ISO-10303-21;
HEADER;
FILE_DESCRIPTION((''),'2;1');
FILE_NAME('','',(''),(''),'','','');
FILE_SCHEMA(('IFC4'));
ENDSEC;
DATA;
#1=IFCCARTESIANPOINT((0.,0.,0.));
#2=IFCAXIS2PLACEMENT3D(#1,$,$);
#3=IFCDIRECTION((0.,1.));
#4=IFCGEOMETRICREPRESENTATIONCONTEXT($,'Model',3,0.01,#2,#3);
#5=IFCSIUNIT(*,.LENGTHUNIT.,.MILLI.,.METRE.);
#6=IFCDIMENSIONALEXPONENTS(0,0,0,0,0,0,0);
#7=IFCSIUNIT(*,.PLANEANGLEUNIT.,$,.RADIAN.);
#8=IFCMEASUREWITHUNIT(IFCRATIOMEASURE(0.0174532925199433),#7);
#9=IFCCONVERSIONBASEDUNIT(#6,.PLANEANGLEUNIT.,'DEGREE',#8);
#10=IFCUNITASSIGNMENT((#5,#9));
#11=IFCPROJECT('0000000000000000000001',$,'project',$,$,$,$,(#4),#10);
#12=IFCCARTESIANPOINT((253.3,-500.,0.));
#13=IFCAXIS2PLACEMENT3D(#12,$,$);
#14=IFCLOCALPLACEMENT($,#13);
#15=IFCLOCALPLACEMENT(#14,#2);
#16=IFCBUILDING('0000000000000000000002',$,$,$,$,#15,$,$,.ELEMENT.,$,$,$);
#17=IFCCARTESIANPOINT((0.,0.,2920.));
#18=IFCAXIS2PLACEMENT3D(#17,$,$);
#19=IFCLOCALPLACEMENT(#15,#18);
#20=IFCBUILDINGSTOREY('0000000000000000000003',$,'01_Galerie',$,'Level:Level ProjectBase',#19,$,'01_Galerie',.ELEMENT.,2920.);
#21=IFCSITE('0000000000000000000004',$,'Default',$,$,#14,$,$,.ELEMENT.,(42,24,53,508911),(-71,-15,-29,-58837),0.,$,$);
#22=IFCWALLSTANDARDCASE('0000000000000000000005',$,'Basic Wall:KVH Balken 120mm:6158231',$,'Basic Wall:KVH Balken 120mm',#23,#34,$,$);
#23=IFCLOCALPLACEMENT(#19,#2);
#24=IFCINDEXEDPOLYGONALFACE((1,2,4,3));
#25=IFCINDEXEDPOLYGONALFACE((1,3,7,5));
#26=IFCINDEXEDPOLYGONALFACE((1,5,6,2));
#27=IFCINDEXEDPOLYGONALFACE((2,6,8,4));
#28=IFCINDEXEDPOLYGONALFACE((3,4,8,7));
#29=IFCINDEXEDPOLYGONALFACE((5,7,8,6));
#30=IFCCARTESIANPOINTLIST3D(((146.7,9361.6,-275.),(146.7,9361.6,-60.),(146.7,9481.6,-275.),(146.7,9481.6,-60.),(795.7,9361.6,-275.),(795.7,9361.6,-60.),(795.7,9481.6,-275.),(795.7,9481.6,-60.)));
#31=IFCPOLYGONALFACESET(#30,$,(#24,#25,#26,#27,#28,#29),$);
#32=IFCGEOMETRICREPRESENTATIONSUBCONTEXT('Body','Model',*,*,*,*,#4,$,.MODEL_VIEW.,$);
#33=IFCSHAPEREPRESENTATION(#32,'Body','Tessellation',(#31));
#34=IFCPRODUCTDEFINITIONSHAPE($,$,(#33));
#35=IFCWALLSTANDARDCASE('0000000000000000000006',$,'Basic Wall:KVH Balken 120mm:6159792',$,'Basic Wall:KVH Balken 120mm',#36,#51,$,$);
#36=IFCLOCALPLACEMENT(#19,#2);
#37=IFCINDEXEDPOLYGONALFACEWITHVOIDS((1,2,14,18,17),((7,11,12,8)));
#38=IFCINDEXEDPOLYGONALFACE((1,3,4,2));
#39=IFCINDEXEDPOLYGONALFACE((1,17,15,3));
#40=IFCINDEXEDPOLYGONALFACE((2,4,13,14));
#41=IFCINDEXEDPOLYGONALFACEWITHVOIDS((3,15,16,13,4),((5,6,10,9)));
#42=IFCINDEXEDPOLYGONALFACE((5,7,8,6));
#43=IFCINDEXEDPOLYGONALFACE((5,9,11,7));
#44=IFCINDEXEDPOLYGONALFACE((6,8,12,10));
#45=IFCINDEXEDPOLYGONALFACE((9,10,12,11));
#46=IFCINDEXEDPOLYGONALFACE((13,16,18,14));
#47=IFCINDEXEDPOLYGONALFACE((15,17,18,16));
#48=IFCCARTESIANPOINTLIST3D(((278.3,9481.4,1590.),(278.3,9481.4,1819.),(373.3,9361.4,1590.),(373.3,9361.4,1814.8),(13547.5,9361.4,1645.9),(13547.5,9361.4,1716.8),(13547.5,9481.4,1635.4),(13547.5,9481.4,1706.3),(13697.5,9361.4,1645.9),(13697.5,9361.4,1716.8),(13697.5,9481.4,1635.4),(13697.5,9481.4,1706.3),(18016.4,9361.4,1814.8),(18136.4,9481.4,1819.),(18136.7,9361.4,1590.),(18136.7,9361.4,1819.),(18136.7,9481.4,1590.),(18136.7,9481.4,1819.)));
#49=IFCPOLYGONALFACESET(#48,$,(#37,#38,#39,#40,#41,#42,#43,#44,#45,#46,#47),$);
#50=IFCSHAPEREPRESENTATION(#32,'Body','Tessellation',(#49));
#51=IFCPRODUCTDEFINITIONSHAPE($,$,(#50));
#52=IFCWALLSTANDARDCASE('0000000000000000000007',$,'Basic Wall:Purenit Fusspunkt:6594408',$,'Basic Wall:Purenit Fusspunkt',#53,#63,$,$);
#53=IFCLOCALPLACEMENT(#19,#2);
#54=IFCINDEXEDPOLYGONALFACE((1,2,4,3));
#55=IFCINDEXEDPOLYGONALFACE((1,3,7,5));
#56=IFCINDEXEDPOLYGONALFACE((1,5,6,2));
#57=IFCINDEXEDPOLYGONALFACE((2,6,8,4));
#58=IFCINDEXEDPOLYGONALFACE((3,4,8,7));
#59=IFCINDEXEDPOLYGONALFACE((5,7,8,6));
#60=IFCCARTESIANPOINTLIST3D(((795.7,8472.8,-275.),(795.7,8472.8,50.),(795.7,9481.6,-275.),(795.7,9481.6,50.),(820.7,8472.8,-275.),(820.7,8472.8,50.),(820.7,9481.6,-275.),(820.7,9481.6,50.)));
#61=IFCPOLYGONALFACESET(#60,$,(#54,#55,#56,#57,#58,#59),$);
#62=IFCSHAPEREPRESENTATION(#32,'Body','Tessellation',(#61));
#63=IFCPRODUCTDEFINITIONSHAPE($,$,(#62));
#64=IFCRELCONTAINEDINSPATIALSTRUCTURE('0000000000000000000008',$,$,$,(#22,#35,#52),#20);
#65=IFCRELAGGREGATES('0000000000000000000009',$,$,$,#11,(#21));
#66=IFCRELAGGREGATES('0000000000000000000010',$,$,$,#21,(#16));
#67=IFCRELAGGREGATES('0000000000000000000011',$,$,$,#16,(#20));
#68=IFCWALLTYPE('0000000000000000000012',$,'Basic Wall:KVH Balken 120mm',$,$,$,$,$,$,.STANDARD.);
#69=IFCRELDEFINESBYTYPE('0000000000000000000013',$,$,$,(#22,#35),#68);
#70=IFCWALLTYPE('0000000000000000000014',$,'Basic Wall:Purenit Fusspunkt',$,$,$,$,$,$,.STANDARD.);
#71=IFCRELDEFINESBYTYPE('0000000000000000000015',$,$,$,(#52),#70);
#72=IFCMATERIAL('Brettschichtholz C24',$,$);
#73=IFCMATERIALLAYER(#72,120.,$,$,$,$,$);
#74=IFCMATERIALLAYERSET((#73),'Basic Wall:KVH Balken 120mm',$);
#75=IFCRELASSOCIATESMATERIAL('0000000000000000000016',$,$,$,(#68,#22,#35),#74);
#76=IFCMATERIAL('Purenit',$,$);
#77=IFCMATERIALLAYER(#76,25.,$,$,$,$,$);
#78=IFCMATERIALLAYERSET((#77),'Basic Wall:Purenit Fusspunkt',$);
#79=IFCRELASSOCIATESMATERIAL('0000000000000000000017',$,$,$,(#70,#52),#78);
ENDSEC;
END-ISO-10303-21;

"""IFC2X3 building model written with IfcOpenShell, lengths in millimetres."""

from ifc_helpers import new_model, entity, si_unit, converted_unit, direction, frame, frame_2d, origin, place, context, subcontext, project, spatial, polyline, rectangle, outline, extrude, clip, bounded_halfspace, material, layer, layer_set, layer_usage, type_object, element, save


model = new_model("IFC2X3")

# Units and contexts
model_context = context("Model", 3, precision=0.01, world=origin(), true_north=direction((0.0, 1.0)))
body_context = subcontext(model_context, "Body", "Model", "MODEL_VIEW")
ifc_project = project(units=[si_unit("LENGTHUNIT", "METRE", prefix="MILLI"), converted_unit("PLANEANGLEUNIT", "DEGREE", entity("IfcRatioMeasure", 0.0174532925199433), si_unit("PLANEANGLEUNIT", "RADIAN"), dimensions=[0, 0, 0, 0, 0, 0, 0])], contexts=[model_context])

# Site, building, storey
site_placement = place(None, frame((253.3, -500.0, 0.0)))
site = spatial("IfcSite", under=ifc_project, at=site_placement, Name="Default", CompositionType="ELEMENT", RefLatitude=(42, 24, 53, 508911), RefLongitude=(-71, -15, -29, -58837), RefElevation=0.0)
building_placement = place(site_placement, origin())
building = spatial("IfcBuilding", under=site, at=building_placement, CompositionType="ELEMENT")
storey_placement = place(building_placement, frame((0.0, 0.0, 2920.0)))
storey = spatial("IfcBuildingStorey", under=building, at=storey_placement, Name="01_Galerie", ObjectType="Level:Level ProjectBase", LongName="01_Galerie", CompositionType="ELEMENT", Elevation=2920.0)

# Wall
ifc_material_1 = material(Name="Brettschichtholz C24")
ifc_layer_1 = layer(ifc_material_1, 120.0)
ifc_layer_set_1 = layer_set([ifc_layer_1], Name="Basic Wall:KVH Balken 120mm")
ifc_layer_usage_1 = layer_usage(ifc_layer_set_1, "AXIS2", "NEGATIVE", 60.0)
wall_type_1 = type_object("IfcWallType", Name="Basic Wall:KVH Balken 120mm", PredefinedType="STANDARD", material=ifc_layer_set_1)
wall_1_placement = place(storey_placement, frame((146.7, 9421.6, -275.0)))
element("IfcWallStandardCase", 1, at=wall_1_placement, inside=storey, type_object=wall_type_1, material=ifc_layer_usage_1, Name="Basic Wall:KVH Balken 120mm:6158231", ObjectType="Basic Wall:KVH Balken 120mm", context=body_context, shape_type="SweptSolid", body=[
    extrude(rectangle(XDim=649.0, YDim=120.0, at=frame_2d((324.5, 0.0), x_axis=(-1.0, 0.0))), origin(), (0.0, 0.0, 1.0), 215.0),
])

# Wall, opening
ifc_layer_usage_2 = layer_usage(ifc_layer_set_1, "AXIS2", "NEGATIVE", 60.0)
wall_2_placement = place(storey_placement, frame((278.3, 9421.4, 1590.0)))
wall_2 = element("IfcWallStandardCase", 2, at=wall_2_placement, inside=storey, type_object=wall_type_1, material=ifc_layer_usage_2, Name="Basic Wall:KVH Balken 120mm:6159792", ObjectType="Basic Wall:KVH Balken 120mm", context=body_context, shape_type="Clipping", body=[
    clip(clip(extrude(outline(polyline([(17858.3, -60.0), (17858.3, 60.0), (0.0, 60.0), (95.0, -60.0), (17738.3, -60.0), (17858.3, -60.0)])), origin(), (0.0, 0.0, 1.0), 229.0), bounded_halfspace(frame((0.0, 60.0, 229.0), z_axis=(0.0, 0.034899, -0.999391), x_axis=(1.0, 0.0, 0.0)), True, frame((0.0, 60.0, 229.0)), polyline([(0.0, 0.0), (95.0, -120.0), (17738.0, -120.0), (17858.0, 0.0), (0.0, 0.0)]))), bounded_halfspace(frame((17858.3, -60.0, 229.0), z_axis=(0.034899, 0.0, -0.999391), x_axis=(0.0, -1.0, 0.0)), True, frame((17858.3, -60.0, 229.0)), polyline([(0.0, 0.0), (0.0, 120.0), (-0.3, 120.0), (-120.3, 0.0), (-120.0, 0.0), (0.0, 0.0)]))),
])
opening_1_placement = place(wall_2_placement, frame((13269.2, -167.4, 20.4)))
element("IfcOpeningElement", 3, at=opening_1_placement, cuts=wall_2, ObjectType="Opening", context=body_context, shape_type="SweptSolid", body=[
    extrude(rectangle(XDim=70.7, YDim=150.0, at=frame_2d((0.0, 0.0), x_axis=(0.0, 1.0))), frame((75.0, 3.1, 80.1), z_axis=(0.0, 0.996195, -0.087156), x_axis=(1.0, 0.0, 0.0)), (0.0, 0.0, 1.0), 514.7),
])

# Wall
ifc_material_2 = material(Name="Purenit")
ifc_layer_2 = layer(ifc_material_2, 25.0)
ifc_layer_set_2 = layer_set([ifc_layer_2], Name="Basic Wall:Purenit Fusspunkt")
ifc_layer_usage_3 = layer_usage(ifc_layer_set_2, "AXIS2", "POSITIVE", -12.5)
wall_type_2 = type_object("IfcWallType", Name="Basic Wall:Purenit Fusspunkt", PredefinedType="STANDARD", material=ifc_layer_set_2)
wall_3_placement = place(storey_placement, frame((808.2, 8472.8, -275.0), z_axis=(0.0, 0.0, 1.0), x_axis=(0.0, 1.0, 0.0)))
element("IfcWallStandardCase", 4, at=wall_3_placement, inside=storey, type_object=wall_type_2, material=ifc_layer_usage_3, Name="Basic Wall:Purenit Fusspunkt:6594408", ObjectType="Basic Wall:Purenit Fusspunkt", context=body_context, shape_type="SweptSolid", body=[
    extrude(rectangle(XDim=1008.9, YDim=25.0, at=frame_2d((504.4, 0.0), x_axis=(-1.0, 0.0))), origin(), (0.0, 0.0, 1.0), 325.0),
])

save(model, "model.ifc")
